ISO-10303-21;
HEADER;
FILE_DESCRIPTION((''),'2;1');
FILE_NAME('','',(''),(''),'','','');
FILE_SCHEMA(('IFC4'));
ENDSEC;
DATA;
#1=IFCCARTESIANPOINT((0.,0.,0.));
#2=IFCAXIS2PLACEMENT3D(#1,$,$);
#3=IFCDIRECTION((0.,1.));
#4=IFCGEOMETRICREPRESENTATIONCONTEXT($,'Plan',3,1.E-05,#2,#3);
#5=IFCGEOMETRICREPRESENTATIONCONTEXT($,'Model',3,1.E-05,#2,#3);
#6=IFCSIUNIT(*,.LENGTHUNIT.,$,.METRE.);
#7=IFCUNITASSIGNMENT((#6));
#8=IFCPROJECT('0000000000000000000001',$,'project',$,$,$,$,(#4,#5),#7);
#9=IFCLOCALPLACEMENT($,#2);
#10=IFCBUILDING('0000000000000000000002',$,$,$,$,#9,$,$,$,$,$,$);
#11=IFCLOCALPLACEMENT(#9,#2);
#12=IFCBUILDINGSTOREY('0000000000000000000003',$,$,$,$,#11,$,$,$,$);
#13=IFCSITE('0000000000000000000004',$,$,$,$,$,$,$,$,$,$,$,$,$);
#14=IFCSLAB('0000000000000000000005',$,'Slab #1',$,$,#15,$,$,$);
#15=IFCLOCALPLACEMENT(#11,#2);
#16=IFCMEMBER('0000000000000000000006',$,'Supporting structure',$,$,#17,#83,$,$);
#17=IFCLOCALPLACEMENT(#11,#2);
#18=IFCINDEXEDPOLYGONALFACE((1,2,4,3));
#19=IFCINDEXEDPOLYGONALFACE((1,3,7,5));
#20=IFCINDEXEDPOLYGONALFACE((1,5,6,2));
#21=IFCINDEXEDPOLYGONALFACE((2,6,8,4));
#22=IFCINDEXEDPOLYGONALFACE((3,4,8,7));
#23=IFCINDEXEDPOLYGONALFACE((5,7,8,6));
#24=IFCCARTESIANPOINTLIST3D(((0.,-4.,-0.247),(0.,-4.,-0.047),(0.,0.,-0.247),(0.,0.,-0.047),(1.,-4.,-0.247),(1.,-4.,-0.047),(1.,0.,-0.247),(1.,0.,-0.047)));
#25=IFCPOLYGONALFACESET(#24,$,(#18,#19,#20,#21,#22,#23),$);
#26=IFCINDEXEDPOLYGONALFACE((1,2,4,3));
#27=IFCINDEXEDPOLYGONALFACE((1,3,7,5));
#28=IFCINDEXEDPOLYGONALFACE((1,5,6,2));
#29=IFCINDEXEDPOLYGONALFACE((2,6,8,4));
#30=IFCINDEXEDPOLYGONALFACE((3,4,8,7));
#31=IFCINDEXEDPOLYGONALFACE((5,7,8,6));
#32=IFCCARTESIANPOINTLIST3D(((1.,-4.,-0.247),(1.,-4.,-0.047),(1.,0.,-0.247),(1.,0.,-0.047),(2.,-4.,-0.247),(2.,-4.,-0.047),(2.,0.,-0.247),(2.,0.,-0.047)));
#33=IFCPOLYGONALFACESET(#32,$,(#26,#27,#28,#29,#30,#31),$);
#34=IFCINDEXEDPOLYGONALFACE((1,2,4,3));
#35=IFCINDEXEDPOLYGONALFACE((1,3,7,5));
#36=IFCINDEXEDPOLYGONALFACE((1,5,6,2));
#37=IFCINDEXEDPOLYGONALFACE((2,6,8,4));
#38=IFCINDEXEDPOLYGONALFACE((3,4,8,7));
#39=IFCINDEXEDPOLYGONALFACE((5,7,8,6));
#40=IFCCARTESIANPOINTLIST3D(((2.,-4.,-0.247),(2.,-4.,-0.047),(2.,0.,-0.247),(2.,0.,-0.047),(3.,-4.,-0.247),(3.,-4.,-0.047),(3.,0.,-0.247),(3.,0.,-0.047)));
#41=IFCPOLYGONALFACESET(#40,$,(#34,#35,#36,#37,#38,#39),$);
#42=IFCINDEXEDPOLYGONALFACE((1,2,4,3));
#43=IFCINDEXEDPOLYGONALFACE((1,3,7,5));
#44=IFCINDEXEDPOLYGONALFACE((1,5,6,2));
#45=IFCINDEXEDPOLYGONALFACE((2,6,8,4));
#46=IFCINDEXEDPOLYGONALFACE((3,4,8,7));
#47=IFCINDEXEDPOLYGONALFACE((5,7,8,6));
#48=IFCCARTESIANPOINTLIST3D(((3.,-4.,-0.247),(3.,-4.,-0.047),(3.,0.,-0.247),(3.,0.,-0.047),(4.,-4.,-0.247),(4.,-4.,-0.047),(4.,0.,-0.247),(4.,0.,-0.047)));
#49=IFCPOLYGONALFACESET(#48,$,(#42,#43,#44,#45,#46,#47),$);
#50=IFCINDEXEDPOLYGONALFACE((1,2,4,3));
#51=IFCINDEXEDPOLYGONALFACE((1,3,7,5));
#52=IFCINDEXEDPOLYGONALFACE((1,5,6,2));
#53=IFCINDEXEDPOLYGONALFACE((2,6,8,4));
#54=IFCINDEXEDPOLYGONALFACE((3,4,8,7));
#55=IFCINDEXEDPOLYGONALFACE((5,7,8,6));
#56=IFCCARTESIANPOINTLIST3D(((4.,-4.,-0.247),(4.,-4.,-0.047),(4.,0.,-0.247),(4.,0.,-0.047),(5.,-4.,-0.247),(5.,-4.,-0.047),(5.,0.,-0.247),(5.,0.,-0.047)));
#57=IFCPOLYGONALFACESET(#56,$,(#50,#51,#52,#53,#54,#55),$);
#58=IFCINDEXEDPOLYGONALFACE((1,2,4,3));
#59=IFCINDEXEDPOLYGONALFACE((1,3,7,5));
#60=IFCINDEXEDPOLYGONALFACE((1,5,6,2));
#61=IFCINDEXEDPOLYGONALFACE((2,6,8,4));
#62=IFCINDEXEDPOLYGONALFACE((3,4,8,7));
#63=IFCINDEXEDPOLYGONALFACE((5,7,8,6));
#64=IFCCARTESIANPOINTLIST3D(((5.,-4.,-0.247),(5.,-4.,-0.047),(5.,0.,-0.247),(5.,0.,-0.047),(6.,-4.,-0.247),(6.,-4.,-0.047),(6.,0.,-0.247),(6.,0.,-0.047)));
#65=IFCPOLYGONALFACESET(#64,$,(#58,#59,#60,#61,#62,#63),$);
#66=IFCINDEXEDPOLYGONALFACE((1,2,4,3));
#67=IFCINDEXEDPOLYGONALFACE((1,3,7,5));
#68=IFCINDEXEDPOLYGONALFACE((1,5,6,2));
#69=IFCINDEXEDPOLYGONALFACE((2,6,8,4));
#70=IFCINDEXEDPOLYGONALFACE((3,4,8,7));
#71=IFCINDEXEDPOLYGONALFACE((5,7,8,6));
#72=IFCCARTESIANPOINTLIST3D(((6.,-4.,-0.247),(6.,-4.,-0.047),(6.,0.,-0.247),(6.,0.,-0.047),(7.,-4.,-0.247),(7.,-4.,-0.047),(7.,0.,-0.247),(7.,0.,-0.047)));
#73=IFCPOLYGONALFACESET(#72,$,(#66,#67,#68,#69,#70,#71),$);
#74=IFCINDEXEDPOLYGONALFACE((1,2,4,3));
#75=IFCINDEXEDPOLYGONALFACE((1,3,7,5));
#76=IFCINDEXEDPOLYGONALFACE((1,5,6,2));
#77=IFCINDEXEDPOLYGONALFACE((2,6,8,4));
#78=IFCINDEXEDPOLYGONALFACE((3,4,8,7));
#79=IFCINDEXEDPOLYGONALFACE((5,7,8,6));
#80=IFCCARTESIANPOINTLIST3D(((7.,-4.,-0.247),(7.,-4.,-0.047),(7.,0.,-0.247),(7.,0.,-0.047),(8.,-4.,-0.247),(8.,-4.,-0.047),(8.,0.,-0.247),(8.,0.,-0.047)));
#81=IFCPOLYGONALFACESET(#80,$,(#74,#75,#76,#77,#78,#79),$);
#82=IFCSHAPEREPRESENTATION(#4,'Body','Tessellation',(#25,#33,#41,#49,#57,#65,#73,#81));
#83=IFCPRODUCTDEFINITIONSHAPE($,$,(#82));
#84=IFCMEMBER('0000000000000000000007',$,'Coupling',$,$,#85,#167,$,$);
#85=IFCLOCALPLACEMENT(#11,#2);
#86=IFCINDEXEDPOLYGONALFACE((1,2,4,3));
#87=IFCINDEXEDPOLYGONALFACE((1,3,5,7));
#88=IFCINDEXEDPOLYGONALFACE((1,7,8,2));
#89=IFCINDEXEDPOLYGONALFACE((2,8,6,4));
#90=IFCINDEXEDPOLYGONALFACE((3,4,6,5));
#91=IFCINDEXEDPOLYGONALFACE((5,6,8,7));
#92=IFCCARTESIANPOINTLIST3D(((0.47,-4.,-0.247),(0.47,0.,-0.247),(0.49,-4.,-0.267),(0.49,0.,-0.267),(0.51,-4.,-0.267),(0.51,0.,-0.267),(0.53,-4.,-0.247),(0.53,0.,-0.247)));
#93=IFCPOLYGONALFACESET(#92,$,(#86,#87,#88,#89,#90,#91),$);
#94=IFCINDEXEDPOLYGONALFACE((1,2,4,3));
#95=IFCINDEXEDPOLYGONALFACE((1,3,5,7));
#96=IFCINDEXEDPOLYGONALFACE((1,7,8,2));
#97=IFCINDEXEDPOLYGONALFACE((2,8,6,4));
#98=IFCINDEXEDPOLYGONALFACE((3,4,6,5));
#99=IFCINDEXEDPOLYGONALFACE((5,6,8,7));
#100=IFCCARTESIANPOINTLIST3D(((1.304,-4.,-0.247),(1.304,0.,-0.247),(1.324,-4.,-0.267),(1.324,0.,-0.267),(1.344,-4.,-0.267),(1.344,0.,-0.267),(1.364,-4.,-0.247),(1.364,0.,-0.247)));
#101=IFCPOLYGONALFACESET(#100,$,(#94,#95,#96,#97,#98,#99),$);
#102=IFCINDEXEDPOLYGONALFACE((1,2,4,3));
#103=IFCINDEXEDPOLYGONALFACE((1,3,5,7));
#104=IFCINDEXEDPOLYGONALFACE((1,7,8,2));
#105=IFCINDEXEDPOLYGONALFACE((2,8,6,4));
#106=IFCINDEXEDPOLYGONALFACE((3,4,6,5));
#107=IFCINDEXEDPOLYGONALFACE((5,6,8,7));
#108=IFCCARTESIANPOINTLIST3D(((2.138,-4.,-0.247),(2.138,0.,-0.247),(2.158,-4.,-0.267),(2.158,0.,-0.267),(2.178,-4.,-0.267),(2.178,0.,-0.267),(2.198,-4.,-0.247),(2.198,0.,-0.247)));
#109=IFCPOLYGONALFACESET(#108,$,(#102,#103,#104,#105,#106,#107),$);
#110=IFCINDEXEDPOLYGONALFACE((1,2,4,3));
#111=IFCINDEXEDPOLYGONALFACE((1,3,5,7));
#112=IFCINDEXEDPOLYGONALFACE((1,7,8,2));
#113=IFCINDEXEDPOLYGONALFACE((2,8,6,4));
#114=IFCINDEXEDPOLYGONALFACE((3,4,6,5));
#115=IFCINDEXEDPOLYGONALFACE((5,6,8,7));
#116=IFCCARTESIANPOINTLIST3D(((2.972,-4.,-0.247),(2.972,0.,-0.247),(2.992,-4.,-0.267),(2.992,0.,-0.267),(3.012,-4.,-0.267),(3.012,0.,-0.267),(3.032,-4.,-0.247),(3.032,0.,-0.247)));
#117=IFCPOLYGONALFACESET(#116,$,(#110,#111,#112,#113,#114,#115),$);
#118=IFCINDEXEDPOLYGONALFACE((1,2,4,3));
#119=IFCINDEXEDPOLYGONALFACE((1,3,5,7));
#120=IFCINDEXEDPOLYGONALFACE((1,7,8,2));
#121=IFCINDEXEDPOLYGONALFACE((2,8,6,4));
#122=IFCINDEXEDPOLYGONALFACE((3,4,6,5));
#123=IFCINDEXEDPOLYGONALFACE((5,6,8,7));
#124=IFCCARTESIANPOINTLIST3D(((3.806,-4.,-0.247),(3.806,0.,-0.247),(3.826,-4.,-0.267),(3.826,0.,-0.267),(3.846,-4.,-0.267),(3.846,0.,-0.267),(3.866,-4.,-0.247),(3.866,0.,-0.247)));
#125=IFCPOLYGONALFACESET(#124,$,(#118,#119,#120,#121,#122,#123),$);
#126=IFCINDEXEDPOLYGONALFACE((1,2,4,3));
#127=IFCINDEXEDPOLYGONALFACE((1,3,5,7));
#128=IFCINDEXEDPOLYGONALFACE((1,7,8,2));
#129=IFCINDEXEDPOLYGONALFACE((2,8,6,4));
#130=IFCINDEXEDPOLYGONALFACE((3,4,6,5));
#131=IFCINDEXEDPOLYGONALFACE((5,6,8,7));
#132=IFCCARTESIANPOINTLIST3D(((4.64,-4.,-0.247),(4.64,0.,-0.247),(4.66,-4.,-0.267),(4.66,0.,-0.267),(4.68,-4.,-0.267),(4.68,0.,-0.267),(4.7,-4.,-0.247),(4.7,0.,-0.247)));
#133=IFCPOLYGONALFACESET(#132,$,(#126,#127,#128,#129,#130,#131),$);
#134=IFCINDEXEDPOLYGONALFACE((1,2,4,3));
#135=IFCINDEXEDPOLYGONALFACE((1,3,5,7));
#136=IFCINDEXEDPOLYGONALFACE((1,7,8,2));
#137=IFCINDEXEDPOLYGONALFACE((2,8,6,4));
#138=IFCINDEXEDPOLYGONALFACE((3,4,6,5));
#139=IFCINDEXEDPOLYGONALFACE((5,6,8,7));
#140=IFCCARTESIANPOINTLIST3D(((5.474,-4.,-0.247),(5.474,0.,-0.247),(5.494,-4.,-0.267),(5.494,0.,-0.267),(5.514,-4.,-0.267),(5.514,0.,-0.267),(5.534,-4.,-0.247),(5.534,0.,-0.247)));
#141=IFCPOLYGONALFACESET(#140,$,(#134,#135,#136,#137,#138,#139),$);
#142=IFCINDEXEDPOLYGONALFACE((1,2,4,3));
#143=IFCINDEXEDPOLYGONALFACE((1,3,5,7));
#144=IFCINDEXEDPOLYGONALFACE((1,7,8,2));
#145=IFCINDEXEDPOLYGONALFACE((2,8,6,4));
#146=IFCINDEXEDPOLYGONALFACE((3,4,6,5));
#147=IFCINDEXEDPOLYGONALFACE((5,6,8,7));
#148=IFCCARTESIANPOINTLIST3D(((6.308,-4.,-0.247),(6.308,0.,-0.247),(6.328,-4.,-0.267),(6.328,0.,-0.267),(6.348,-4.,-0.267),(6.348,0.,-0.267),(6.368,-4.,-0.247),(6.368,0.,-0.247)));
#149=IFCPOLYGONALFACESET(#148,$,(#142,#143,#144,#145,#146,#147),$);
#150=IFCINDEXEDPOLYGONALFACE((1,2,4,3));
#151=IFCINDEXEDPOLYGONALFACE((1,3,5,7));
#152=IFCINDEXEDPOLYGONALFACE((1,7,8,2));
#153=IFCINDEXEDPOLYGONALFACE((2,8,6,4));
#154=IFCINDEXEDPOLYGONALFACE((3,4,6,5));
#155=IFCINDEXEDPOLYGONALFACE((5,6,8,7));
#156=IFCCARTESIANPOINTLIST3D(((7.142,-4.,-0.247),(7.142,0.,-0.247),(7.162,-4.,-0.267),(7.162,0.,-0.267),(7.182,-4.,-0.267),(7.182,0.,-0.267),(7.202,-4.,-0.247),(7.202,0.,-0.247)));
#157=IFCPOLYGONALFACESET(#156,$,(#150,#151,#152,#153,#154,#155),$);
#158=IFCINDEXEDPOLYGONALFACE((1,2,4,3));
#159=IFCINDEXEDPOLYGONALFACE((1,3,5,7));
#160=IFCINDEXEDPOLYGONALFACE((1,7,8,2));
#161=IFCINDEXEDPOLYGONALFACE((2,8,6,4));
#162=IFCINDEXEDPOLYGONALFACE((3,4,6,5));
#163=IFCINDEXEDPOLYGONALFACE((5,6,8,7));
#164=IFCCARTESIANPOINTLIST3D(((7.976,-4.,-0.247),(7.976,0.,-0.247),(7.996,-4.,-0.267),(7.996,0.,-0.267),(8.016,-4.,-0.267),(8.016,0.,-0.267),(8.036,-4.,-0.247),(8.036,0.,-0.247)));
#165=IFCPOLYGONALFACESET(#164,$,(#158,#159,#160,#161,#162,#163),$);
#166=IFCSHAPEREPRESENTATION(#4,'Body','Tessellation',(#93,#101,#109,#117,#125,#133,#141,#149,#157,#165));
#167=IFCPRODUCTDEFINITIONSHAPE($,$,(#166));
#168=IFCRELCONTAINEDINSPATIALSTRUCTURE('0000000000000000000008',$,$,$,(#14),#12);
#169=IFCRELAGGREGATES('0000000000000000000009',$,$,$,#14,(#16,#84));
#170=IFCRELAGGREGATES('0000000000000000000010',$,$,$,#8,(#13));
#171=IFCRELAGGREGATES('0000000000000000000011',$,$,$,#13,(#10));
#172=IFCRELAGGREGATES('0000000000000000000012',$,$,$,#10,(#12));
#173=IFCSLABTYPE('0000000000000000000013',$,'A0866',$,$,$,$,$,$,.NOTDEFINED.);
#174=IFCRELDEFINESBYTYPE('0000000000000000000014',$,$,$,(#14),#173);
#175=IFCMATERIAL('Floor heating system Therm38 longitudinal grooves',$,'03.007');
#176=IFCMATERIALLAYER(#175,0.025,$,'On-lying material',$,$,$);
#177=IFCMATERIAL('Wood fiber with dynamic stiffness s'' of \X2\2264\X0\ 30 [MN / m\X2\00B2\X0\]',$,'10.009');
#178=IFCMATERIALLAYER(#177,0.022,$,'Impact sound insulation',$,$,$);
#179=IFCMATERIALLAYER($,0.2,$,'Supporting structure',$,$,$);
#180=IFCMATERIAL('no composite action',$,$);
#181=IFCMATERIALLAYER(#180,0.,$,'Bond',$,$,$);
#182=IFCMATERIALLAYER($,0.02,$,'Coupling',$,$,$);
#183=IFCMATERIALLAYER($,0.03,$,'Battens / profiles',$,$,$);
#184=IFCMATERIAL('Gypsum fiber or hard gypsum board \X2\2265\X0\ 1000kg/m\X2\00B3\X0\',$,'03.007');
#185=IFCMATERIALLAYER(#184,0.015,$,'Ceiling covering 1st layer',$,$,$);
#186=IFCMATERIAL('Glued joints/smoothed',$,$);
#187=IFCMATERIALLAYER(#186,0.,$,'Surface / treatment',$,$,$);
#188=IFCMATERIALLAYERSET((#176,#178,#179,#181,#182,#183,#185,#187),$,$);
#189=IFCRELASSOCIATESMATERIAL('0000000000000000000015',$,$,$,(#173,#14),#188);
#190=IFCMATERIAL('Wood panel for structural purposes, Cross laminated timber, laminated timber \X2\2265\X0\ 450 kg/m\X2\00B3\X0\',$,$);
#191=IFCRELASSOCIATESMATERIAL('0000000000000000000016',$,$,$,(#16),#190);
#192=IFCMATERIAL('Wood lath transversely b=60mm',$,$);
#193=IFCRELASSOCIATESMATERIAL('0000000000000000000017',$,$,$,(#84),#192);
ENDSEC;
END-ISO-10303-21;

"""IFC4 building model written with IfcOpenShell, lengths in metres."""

from ifc_helpers import new_model, si_unit, direction, frame, frame_2d, origin, place, context, project, spatial, polyline, rectangle, outline, extrude, material, layer, layer_set, type_object, element, aggregate, save


model = new_model("IFC4")

# Units and contexts
plan_context = context("Plan", 3, precision=1e-05, world=origin(), true_north=direction((0.0, 1.0)))
model_context = context("Model", 3, precision=1e-05, world=origin(), true_north=direction((0.0, 1.0)))
ifc_project = project(units=[si_unit("LENGTHUNIT", "METRE")], contexts=[plan_context, model_context])

# Site, building, storey
site = spatial("IfcSite", under=ifc_project)
building_placement = place(None, origin())
building = spatial("IfcBuilding", under=site, at=building_placement)
storey_placement = place(building_placement, origin())
storey = spatial("IfcBuildingStorey", under=building, at=storey_placement)

# Slab, members
ifc_material_1 = material(Name="Floor heating system Therm38 longitudinal grooves", Category="03.007")
ifc_layer_1 = layer(ifc_material_1, 0.025, Name="On-lying material")
ifc_material_2 = material(Name="Wood fiber with dynamic stiffness s' of ≤ 30 [MN / m²]", Category="10.009")
ifc_layer_2 = layer(ifc_material_2, 0.022, Name="Impact sound insulation")
ifc_layer_3 = layer(None, 0.2, Name="Supporting structure")
ifc_material_3 = material(Name="no composite action")
ifc_layer_4 = layer(ifc_material_3, 0.0, Name="Bond")
ifc_layer_5 = layer(None, 0.02, Name="Coupling")
ifc_layer_6 = layer(None, 0.03, Name="Battens / profiles")
ifc_material_4 = material(Name="Gypsum fiber or hard gypsum board ≥ 1000kg/m³", Category="03.007")
ifc_layer_7 = layer(ifc_material_4, 0.015, Name="Ceiling covering 1st layer")
ifc_material_5 = material(Name="Glued joints/smoothed")
ifc_layer_8 = layer(ifc_material_5, 0.0, Name="Surface / treatment")
ifc_layer_set = layer_set([ifc_layer_1, ifc_layer_2, ifc_layer_3, ifc_layer_4, ifc_layer_5, ifc_layer_6, ifc_layer_7, ifc_layer_8])
slab_type = type_object("IfcSlabType", Name="A0866", PredefinedType="NOTDEFINED", material=ifc_layer_set)
slab_placement = place(None, frame((0.0, 0.0, 0.0), z_axis=(0.0, 0.0, -1.0), x_axis=(1.0, 0.0, 0.0)))
slab = element("IfcSlab", 1, at=slab_placement, inside=storey, type_object=slab_type, material=ifc_layer_set, Name="Slab #1")
ifc_material_6 = material(Name="Wood panel for structural purposes, Cross laminated timber, laminated timber ≥ 450 kg/m³")
member_1_placement = place(slab_placement, origin())
member_1 = element("IfcMember", 2, at=member_1_placement, material=ifc_material_6, Name="Supporting structure", context=plan_context, shape_type="SweptSolid", body=[
    extrude(rectangle(XDim=1.0, YDim=0.2, at=frame_2d((0.5, 0.1), x_axis=(1.0, 0.0))), frame((0.0, 4.0, 0.047), z_axis=(0.0, -1.0, 0.0), x_axis=(1.0, 0.0, 0.0)), (0.0, 0.0, 1.0), 4.0),
    extrude(rectangle(XDim=1.0, YDim=0.2, at=frame_2d((0.5, 0.1), x_axis=(1.0, 0.0))), frame((1.0, 4.0, 0.047), z_axis=(0.0, -1.0, 0.0), x_axis=(1.0, 0.0, 0.0)), (0.0, 0.0, 1.0), 4.0),
    extrude(rectangle(XDim=1.0, YDim=0.2, at=frame_2d((0.5, 0.1), x_axis=(1.0, 0.0))), frame((2.0, 4.0, 0.047), z_axis=(0.0, -1.0, 0.0), x_axis=(1.0, 0.0, 0.0)), (0.0, 0.0, 1.0), 4.0),
    extrude(rectangle(XDim=1.0, YDim=0.2, at=frame_2d((0.5, 0.1), x_axis=(1.0, 0.0))), frame((3.0, 4.0, 0.047), z_axis=(0.0, -1.0, 0.0), x_axis=(1.0, 0.0, 0.0)), (0.0, 0.0, 1.0), 4.0),
    extrude(rectangle(XDim=1.0, YDim=0.2, at=frame_2d((0.5, 0.1), x_axis=(1.0, 0.0))), frame((4.0, 4.0, 0.047), z_axis=(0.0, -1.0, 0.0), x_axis=(1.0, 0.0, 0.0)), (0.0, 0.0, 1.0), 4.0),
    extrude(rectangle(XDim=1.0, YDim=0.2, at=frame_2d((0.5, 0.1), x_axis=(1.0, 0.0))), frame((5.0, 4.0, 0.047), z_axis=(0.0, -1.0, 0.0), x_axis=(1.0, 0.0, 0.0)), (0.0, 0.0, 1.0), 4.0),
    extrude(rectangle(XDim=1.0, YDim=0.2, at=frame_2d((0.5, 0.1), x_axis=(1.0, 0.0))), frame((6.0, 4.0, 0.047), z_axis=(0.0, -1.0, 0.0), x_axis=(1.0, 0.0, 0.0)), (0.0, 0.0, 1.0), 4.0),
    extrude(rectangle(XDim=1.0, YDim=0.2, at=frame_2d((0.5, 0.1), x_axis=(1.0, 0.0))), frame((7.0, 4.0, 0.047), z_axis=(0.0, -1.0, 0.0), x_axis=(1.0, 0.0, 0.0)), (0.0, 0.0, 1.0), 4.0),
])
ifc_material_7 = material(Name="Wood lath transversely b=60mm")
member_2_placement = place(slab_placement, origin())
member_2 = element("IfcMember", 3, at=member_2_placement, material=ifc_material_7, Name="Coupling", context=plan_context, shape_type="SweptSolid", body=[
    extrude(outline(polyline([(0.0, 0.0), (0.06, 0.0), (0.04, 0.02), (0.02, 0.02), (0.0, 0.0)])), frame((0.47, 4.0, 0.247), z_axis=(0.0, -1.0, 0.0), x_axis=(1.0, 0.0, 0.0)), (0.0, 0.0, 1.0), 4.0),
    extrude(outline(polyline([(0.0, 0.0), (0.06, 0.0), (0.04, 0.02), (0.02, 0.02), (0.0, 0.0)])), frame((1.304, 4.0, 0.247), z_axis=(0.0, -1.0, 0.0), x_axis=(1.0, 0.0, 0.0)), (0.0, 0.0, 1.0), 4.0),
    extrude(outline(polyline([(0.0, 0.0), (0.06, 0.0), (0.04, 0.02), (0.02, 0.02), (0.0, 0.0)])), frame((2.138, 4.0, 0.247), z_axis=(0.0, -1.0, 0.0), x_axis=(1.0, 0.0, 0.0)), (0.0, 0.0, 1.0), 4.0),
    extrude(outline(polyline([(0.0, 0.0), (0.06, 0.0), (0.04, 0.02), (0.02, 0.02), (0.0, 0.0)])), frame((2.972, 4.0, 0.247), z_axis=(0.0, -1.0, 0.0), x_axis=(1.0, 0.0, 0.0)), (0.0, 0.0, 1.0), 4.0),
    extrude(outline(polyline([(0.0, 0.0), (0.06, 0.0), (0.04, 0.02), (0.02, 0.02), (0.0, 0.0)])), frame((3.806, 4.0, 0.247), z_axis=(0.0, -1.0, 0.0), x_axis=(1.0, 0.0, 0.0)), (0.0, 0.0, 1.0), 4.0),
    extrude(outline(polyline([(0.0, 0.0), (0.06, 0.0), (0.04, 0.02), (0.02, 0.02), (0.0, 0.0)])), frame((4.64, 4.0, 0.247), z_axis=(0.0, -1.0, 0.0), x_axis=(1.0, 0.0, 0.0)), (0.0, 0.0, 1.0), 4.0),
    extrude(outline(polyline([(0.0, 0.0), (0.06, 0.0), (0.04, 0.02), (0.02, 0.02), (0.0, 0.0)])), frame((5.474, 4.0, 0.247), z_axis=(0.0, -1.0, 0.0), x_axis=(1.0, 0.0, 0.0)), (0.0, 0.0, 1.0), 4.0),
    extrude(outline(polyline([(0.0, 0.0), (0.06, 0.0), (0.04, 0.02), (0.02, 0.02), (0.0, 0.0)])), frame((6.308, 4.0, 0.247), z_axis=(0.0, -1.0, 0.0), x_axis=(1.0, 0.0, 0.0)), (0.0, 0.0, 1.0), 4.0),
    extrude(outline(polyline([(0.0, 0.0), (0.06, 0.0), (0.04, 0.02), (0.02, 0.02), (0.0, 0.0)])), frame((7.142, 4.0, 0.247), z_axis=(0.0, -1.0, 0.0), x_axis=(1.0, 0.0, 0.0)), (0.0, 0.0, 1.0), 4.0),
    extrude(outline(polyline([(0.0, 0.0), (0.06, 0.0), (0.04, 0.02), (0.02, 0.02), (0.0, 0.0)])), frame((7.976, 4.0, 0.247), z_axis=(0.0, -1.0, 0.0), x_axis=(1.0, 0.0, 0.0)), (0.0, 0.0, 1.0), 4.0),
])
aggregate(slab, [member_1, member_2])

save(model, "model.ifc")
